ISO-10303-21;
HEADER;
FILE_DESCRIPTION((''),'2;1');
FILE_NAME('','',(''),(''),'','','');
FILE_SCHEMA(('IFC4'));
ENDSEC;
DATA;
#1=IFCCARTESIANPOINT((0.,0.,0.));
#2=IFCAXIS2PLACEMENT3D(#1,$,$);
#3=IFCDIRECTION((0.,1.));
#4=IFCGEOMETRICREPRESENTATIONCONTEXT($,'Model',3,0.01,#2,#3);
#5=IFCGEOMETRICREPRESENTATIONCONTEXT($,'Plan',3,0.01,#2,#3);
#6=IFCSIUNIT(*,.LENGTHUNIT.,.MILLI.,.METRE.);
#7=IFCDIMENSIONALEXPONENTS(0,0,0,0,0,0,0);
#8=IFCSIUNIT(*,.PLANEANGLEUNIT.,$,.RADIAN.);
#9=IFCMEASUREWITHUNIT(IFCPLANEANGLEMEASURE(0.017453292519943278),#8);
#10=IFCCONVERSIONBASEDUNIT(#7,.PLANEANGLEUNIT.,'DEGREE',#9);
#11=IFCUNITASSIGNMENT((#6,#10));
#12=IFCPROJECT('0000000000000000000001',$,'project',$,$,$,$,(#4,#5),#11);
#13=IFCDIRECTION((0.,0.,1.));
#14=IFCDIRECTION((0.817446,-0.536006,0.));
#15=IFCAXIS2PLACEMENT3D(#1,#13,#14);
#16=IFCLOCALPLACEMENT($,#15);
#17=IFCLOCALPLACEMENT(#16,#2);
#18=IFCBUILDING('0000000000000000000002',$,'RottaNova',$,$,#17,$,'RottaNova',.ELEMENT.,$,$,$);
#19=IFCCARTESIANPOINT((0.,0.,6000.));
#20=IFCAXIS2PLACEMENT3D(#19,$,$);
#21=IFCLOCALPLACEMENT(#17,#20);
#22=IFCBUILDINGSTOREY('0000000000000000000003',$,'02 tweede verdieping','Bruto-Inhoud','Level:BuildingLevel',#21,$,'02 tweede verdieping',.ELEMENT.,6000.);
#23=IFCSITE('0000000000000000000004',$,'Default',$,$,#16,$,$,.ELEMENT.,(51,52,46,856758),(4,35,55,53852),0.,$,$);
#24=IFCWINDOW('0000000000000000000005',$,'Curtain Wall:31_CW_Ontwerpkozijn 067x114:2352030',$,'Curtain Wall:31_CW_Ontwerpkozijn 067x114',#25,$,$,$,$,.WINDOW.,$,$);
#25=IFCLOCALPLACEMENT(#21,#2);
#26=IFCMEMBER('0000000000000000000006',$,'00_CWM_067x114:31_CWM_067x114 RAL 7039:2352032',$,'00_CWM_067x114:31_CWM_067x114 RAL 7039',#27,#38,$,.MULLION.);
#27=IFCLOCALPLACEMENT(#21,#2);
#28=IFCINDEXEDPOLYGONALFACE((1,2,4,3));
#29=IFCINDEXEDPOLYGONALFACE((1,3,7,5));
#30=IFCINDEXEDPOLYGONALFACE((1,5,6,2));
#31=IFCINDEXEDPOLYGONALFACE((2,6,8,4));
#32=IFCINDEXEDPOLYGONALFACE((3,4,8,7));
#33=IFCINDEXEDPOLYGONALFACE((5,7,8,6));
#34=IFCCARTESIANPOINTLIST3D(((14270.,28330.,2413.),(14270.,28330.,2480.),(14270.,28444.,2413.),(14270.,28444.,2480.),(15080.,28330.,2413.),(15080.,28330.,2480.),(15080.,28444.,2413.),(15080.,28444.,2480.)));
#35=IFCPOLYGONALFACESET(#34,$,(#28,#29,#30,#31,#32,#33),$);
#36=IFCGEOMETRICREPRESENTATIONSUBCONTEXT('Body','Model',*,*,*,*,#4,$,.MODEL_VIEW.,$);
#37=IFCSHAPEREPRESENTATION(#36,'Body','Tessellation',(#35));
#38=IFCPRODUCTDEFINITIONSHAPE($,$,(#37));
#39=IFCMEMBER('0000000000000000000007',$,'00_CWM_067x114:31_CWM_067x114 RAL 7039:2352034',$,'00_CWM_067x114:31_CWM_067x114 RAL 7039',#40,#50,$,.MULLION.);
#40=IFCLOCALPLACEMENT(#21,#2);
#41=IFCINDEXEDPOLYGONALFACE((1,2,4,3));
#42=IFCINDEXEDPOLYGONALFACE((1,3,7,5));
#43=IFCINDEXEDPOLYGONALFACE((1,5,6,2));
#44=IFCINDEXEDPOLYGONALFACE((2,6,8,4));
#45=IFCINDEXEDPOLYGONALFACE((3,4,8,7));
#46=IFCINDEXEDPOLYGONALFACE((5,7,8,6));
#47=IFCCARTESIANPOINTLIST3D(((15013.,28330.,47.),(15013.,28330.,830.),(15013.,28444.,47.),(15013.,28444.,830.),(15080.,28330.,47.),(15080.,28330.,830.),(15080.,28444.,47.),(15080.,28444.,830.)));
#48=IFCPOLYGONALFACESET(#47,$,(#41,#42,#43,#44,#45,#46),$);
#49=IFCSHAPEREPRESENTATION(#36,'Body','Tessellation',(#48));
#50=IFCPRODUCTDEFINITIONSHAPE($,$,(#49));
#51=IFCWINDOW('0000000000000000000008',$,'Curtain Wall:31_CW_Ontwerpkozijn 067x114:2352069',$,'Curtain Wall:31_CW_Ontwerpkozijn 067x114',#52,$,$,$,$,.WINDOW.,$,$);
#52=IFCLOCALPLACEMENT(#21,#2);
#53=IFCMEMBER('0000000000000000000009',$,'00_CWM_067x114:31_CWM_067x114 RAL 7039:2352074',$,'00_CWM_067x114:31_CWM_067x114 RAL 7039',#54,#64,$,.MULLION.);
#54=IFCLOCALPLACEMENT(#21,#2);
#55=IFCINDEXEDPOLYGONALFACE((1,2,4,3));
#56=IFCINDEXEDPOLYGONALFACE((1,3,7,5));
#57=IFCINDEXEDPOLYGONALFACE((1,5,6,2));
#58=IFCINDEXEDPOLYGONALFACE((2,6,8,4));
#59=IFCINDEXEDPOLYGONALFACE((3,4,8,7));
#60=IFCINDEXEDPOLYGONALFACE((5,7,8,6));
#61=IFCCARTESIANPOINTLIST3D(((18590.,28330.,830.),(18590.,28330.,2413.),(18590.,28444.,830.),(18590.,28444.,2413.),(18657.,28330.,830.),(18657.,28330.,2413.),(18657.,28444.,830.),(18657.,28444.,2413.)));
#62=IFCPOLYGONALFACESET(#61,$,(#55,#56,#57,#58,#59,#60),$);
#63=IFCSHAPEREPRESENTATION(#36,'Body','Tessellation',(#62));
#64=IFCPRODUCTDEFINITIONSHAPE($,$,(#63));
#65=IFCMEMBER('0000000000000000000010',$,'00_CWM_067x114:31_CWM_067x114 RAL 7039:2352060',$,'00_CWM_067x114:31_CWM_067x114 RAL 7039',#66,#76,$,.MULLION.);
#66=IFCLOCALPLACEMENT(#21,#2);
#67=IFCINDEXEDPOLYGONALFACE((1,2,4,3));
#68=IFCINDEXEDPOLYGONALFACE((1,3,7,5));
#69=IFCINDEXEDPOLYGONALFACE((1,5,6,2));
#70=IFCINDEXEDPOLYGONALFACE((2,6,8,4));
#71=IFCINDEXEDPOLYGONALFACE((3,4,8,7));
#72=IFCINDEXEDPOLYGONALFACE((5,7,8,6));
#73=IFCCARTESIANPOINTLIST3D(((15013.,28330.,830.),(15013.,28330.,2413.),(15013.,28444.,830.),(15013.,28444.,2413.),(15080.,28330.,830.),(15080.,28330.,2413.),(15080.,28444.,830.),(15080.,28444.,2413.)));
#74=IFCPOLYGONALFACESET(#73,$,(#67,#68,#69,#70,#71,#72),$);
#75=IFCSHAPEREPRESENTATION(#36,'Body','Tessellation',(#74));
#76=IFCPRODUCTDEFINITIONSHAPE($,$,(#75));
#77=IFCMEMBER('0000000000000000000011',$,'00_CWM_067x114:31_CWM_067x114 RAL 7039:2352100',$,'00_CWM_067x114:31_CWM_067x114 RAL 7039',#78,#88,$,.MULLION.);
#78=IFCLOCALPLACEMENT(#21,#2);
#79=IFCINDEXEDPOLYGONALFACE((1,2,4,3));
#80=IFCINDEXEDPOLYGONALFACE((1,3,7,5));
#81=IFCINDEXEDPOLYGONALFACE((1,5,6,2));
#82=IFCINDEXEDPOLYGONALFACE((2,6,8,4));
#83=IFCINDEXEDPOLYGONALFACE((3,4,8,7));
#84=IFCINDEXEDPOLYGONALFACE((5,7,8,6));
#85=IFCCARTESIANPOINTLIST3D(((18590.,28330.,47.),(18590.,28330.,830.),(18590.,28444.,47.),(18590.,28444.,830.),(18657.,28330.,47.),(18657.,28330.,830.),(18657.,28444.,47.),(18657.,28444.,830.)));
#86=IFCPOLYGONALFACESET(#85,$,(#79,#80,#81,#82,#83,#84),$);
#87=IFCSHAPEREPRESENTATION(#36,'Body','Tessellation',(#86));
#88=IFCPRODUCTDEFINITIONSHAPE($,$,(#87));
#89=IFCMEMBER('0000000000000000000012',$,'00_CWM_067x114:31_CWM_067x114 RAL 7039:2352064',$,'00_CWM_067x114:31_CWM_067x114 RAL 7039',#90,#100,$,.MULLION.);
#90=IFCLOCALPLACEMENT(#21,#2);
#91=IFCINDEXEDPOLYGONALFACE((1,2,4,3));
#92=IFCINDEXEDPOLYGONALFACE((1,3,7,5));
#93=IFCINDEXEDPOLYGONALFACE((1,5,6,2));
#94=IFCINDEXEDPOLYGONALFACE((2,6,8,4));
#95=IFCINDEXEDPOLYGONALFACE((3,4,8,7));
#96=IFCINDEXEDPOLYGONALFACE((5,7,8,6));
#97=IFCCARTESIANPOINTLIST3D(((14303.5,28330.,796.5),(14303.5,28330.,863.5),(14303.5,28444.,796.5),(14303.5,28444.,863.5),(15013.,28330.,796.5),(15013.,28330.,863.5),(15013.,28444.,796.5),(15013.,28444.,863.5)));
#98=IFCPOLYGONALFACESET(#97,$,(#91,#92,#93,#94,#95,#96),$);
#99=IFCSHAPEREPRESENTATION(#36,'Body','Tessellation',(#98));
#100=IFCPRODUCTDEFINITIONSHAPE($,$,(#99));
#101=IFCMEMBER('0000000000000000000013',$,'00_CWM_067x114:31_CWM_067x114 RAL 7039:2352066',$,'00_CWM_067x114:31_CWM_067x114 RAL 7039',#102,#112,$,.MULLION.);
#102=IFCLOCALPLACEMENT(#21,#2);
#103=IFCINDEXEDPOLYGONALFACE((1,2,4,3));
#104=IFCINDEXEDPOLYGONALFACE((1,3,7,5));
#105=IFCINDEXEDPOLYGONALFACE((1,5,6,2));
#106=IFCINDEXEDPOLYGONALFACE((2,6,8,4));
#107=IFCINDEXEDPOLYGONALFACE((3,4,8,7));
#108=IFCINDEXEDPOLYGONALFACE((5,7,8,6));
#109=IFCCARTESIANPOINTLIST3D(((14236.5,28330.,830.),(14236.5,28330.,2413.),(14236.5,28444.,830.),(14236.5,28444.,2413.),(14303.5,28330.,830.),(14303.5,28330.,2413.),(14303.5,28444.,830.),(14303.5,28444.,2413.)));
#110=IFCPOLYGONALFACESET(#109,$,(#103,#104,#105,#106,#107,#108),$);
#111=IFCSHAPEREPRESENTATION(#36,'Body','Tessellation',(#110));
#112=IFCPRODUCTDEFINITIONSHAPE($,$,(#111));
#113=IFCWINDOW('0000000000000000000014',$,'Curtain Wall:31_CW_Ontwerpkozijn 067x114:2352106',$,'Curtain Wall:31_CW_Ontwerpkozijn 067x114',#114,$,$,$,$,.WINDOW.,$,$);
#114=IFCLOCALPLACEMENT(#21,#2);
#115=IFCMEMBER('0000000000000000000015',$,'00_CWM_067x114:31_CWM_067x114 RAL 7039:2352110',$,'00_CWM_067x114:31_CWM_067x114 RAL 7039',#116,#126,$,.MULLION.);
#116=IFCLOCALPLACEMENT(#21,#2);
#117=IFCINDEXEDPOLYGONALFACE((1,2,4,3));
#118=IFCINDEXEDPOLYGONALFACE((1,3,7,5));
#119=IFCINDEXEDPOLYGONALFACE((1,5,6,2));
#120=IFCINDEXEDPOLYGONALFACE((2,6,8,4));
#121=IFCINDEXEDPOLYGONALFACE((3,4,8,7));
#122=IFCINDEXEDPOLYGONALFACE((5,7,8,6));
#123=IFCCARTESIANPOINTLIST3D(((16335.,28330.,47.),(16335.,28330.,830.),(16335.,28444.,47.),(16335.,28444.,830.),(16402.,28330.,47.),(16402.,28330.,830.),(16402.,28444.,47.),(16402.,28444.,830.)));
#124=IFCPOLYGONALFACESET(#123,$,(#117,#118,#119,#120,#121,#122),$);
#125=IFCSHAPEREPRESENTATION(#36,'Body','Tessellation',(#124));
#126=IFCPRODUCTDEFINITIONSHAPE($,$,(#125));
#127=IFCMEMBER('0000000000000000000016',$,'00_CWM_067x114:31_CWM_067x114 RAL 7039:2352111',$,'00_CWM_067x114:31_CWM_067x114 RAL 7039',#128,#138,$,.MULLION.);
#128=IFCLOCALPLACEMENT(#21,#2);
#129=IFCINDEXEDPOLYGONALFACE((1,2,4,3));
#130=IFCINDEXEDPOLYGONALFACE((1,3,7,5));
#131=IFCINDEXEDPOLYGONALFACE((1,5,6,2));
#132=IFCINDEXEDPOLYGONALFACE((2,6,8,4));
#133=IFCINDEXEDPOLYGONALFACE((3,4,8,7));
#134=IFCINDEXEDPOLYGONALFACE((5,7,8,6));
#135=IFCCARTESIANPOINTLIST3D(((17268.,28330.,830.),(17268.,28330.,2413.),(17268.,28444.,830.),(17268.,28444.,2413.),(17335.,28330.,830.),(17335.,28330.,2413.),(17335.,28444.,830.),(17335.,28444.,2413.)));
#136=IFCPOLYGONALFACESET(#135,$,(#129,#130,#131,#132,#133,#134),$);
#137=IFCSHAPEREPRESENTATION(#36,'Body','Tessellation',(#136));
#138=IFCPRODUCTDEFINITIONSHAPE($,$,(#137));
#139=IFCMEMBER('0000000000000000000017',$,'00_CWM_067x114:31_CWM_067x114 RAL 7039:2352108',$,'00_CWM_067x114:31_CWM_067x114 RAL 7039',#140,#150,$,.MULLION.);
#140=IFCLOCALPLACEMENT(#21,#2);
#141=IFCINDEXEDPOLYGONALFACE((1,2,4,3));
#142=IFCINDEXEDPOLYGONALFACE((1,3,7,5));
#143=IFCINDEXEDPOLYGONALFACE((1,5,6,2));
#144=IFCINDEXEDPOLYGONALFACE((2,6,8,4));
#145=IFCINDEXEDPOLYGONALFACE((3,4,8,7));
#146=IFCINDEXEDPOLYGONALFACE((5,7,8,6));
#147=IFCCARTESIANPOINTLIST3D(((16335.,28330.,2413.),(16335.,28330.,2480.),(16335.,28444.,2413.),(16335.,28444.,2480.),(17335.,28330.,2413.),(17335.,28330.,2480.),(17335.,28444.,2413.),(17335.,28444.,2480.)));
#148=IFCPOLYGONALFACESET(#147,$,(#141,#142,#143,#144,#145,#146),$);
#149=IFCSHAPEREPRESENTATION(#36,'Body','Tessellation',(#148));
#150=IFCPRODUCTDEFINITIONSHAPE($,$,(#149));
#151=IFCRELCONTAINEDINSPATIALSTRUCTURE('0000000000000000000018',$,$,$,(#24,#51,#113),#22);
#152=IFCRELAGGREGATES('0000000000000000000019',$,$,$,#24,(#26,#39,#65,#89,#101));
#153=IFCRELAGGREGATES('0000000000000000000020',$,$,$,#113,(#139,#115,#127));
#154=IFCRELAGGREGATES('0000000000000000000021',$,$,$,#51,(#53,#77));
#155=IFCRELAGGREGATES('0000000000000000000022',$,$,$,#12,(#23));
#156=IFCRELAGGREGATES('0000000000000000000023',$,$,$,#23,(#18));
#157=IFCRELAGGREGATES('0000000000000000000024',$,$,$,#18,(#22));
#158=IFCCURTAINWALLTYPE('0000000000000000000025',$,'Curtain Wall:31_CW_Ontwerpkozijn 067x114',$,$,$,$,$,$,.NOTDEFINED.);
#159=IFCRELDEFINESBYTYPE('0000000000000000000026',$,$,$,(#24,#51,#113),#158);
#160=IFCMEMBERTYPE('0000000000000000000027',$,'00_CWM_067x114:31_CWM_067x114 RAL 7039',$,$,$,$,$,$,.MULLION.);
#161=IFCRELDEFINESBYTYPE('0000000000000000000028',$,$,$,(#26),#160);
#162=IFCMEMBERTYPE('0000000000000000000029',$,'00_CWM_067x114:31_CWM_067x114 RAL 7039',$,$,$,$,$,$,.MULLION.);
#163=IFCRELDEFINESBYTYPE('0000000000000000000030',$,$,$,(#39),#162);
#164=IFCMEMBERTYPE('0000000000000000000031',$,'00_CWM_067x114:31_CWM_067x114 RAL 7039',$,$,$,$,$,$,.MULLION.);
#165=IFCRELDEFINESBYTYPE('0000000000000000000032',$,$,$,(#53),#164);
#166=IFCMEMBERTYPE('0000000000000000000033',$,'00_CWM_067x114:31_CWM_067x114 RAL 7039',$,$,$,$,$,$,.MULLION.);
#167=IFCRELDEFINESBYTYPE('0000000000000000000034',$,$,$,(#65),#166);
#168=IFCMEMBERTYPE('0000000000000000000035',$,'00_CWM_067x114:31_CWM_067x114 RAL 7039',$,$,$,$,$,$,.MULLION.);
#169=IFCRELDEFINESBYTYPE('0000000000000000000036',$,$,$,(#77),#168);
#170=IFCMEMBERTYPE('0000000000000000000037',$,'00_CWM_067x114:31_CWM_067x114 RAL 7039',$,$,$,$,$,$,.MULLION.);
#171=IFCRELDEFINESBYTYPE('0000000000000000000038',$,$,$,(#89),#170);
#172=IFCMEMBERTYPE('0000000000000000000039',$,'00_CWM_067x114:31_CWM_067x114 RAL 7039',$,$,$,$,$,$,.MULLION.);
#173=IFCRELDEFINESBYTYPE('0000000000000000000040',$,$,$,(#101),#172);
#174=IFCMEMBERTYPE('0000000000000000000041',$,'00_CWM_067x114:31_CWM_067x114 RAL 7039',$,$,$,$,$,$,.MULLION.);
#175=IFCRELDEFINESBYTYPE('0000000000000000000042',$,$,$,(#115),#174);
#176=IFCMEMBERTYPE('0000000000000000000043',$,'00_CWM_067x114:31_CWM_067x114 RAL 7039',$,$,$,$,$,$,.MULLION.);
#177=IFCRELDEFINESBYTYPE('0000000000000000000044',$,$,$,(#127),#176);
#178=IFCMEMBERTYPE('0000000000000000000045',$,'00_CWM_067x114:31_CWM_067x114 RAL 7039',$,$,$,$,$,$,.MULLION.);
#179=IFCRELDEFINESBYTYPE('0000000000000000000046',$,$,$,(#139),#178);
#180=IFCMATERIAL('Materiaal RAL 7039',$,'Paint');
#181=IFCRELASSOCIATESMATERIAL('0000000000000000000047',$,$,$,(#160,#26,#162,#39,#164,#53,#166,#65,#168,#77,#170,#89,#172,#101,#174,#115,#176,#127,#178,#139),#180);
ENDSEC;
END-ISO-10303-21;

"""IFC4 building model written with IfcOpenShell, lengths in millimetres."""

from ifc_helpers import new_model, entity, si_unit, converted_unit, direction, frame, origin, place, context, subcontext, project, spatial, indexed_curve, outline, extrude, source, transform, mapped, material, type_object, type_shapes, element, aggregate, save


model = new_model("IFC4")

# Units and contexts
model_context = context("Model", 3, precision=0.01, world=origin(), true_north=direction((0.0, 1.0)))
plan_context = context("Plan", 3, precision=0.01, world=origin(), true_north=direction((0.0, 1.0)))
body_context = subcontext(model_context, "Body", "Model", "MODEL_VIEW")
ifc_project = project(units=[si_unit("LENGTHUNIT", "METRE", prefix="MILLI"), converted_unit("PLANEANGLEUNIT", "DEGREE", entity("IfcPlaneAngleMeasure", 0.017453292519943278), si_unit("PLANEANGLEUNIT", "RADIAN"), dimensions=[0, 0, 0, 0, 0, 0, 0])], contexts=[model_context, plan_context])

# Site, building, storey
site_placement = place(None, frame((0.0, 0.0, 0.0), z_axis=(0.0, 0.0, 1.0), x_axis=(0.817446, -0.536006, 0.0)))
site = spatial("IfcSite", under=ifc_project, at=site_placement, Name="Default", CompositionType="ELEMENT", RefLatitude=(51, 52, 46, 856758), RefLongitude=(4, 35, 55, 53852), RefElevation=0.0)
building_placement = place(site_placement, origin())
building = spatial("IfcBuilding", under=site, at=building_placement, Name="RottaNova", LongName="RottaNova", CompositionType="ELEMENT")
storey_placement = place(building_placement, frame((0.0, 0.0, 6000.0)))
storey = spatial("IfcBuildingStorey", under=building, at=storey_placement, Name="02 tweede verdieping", Description="Bruto-Inhoud", ObjectType="Level:BuildingLevel", LongName="02 tweede verdieping", CompositionType="ELEMENT", Elevation=6000.0)

# Window, members
curtain_wall_type = type_object("IfcCurtainWallType", Name="Curtain Wall:31_CW_Ontwerpkozijn 067x114", PredefinedType="NOTDEFINED")
window_1_placement = place(storey_placement, frame((0.0, 0.0, -6000.0)))
window_1 = element("IfcWindow", 1, at=window_1_placement, inside=storey, type_object=curtain_wall_type, Name="Curtain Wall:31_CW_Ontwerpkozijn 067x114:2352030", ObjectType="Curtain Wall:31_CW_Ontwerpkozijn 067x114", PredefinedType="WINDOW")
ifc_material_1 = material(Name="Materiaal RAL 7039", Category="Paint")
member_type_1 = type_object("IfcMemberType", Name="00_CWM_067x114:31_CWM_067x114 RAL 7039", PredefinedType="MULLION", material=ifc_material_1)
shared_shape_1 = source(origin(), body_context, "Body", "SweptSolid", [
    extrude(outline(indexed_curve([(-33.5, -57.0), (33.5, -57.0), (33.5, 57.0), (-33.5, 57.0), (-33.5, -57.0)], self_intersect=False)), frame((-33.5, -57.0, -810.0), z_axis=(0.0, 0.0, 1.0), x_axis=(-1.0, 0.0, 0.0)), (0.0, 0.0, 1.0), 810.0),
])
type_shapes(member_type_1, [shared_shape_1])
member_1_placement = place(window_1_placement, frame((15080.0, 28330.0, 8480.0), z_axis=(1.0, 0.0, 0.0), x_axis=(0.0, 0.0, 1.0)))
member_1 = element("IfcMember", 2, at=member_1_placement, type_object=member_type_1, material=ifc_material_1, Name="00_CWM_067x114:31_CWM_067x114 RAL 7039:2352032", ObjectType="00_CWM_067x114:31_CWM_067x114 RAL 7039", PredefinedType="MULLION", context=body_context, shape_type="MappedRepresentation", body=[
    mapped(shared_shape_1, transform((0.0, 0.0, 0.0), scale=1.0)),
])
member_type_2 = type_object("IfcMemberType", Name="00_CWM_067x114:31_CWM_067x114 RAL 7039", PredefinedType="MULLION", material=ifc_material_1)
shared_shape_2 = source(origin(), body_context, "Body", "SweptSolid", [
    extrude(outline(indexed_curve([(-33.5, -57.0), (33.5, -57.0), (33.5, 57.0), (-33.5, 57.0), (-33.5, -57.0)], self_intersect=False)), frame((-33.5, -57.0, -783.0), z_axis=(0.0, 0.0, 1.0), x_axis=(-1.0, 0.0, 0.0)), (0.0, 0.0, 1.0), 783.0),
])
type_shapes(member_type_2, [shared_shape_2])
member_2_placement = place(window_1_placement, frame((15080.0, 28330.0, 6047.0), z_axis=(0.0, 0.0, -1.0), x_axis=(1.0, 0.0, 0.0)))
member_2 = element("IfcMember", 3, at=member_2_placement, type_object=member_type_2, material=ifc_material_1, Name="00_CWM_067x114:31_CWM_067x114 RAL 7039:2352034", ObjectType="00_CWM_067x114:31_CWM_067x114 RAL 7039", PredefinedType="MULLION", context=body_context, shape_type="MappedRepresentation", body=[
    mapped(shared_shape_2, transform((0.0, 0.0, 0.0), scale=1.0)),
])

# Window, member
window_2_placement = place(storey_placement, frame((0.0, 0.0, -6000.0)))
window_2 = element("IfcWindow", 4, at=window_2_placement, inside=storey, type_object=curtain_wall_type, Name="Curtain Wall:31_CW_Ontwerpkozijn 067x114:2352069", ObjectType="Curtain Wall:31_CW_Ontwerpkozijn 067x114", PredefinedType="WINDOW")
member_type_3 = type_object("IfcMemberType", Name="00_CWM_067x114:31_CWM_067x114 RAL 7039", PredefinedType="MULLION", material=ifc_material_1)
shared_shape_3 = source(origin(), body_context, "Body", "SweptSolid", [
    extrude(outline(indexed_curve([(-33.5, -57.0), (33.5, -57.0), (33.5, 57.0), (-33.5, 57.0), (-33.5, -57.0)], self_intersect=False)), frame((-33.5, -57.0, -1583.0), z_axis=(0.0, 0.0, 1.0), x_axis=(-1.0, 0.0, 0.0)), (0.0, 0.0, 1.0), 1583.0),
])
type_shapes(member_type_3, [shared_shape_3])
member_3_placement = place(window_2_placement, frame((18590.0, 28330.0, 8413.0), z_axis=(0.0, 0.0, 1.0), x_axis=(-1.0, 0.0, 0.0)))
member_3 = element("IfcMember", 5, at=member_3_placement, type_object=member_type_3, material=ifc_material_1, Name="00_CWM_067x114:31_CWM_067x114 RAL 7039:2352074", ObjectType="00_CWM_067x114:31_CWM_067x114 RAL 7039", PredefinedType="MULLION", context=body_context, shape_type="MappedRepresentation", body=[
    mapped(shared_shape_3, transform((0.0, 0.0, 0.0), scale=1.0)),
])

# Members
member_type_4 = type_object("IfcMemberType", Name="00_CWM_067x114:31_CWM_067x114 RAL 7039", PredefinedType="MULLION", material=ifc_material_1)
shared_shape_4 = source(origin(), body_context, "Body", "SweptSolid", [
    extrude(outline(indexed_curve([(-33.5, -57.0), (33.5, -57.0), (33.5, 57.0), (-33.5, 57.0), (-33.5, -57.0)], self_intersect=False)), frame((-33.5, -57.0, -1583.0), z_axis=(0.0, 0.0, 1.0), x_axis=(-1.0, 0.0, 0.0)), (0.0, 0.0, 1.0), 1583.0),
])
type_shapes(member_type_4, [shared_shape_4])
member_4_placement = place(window_1_placement, frame((15080.0, 28330.0, 6830.0), z_axis=(0.0, 0.0, -1.0), x_axis=(1.0, 0.0, 0.0)))
member_4 = element("IfcMember", 6, at=member_4_placement, type_object=member_type_4, material=ifc_material_1, Name="00_CWM_067x114:31_CWM_067x114 RAL 7039:2352060", ObjectType="00_CWM_067x114:31_CWM_067x114 RAL 7039", PredefinedType="MULLION", context=body_context, shape_type="MappedRepresentation", body=[
    mapped(shared_shape_4, transform((0.0, 0.0, 0.0), scale=1.0)),
])
member_type_5 = type_object("IfcMemberType", Name="00_CWM_067x114:31_CWM_067x114 RAL 7039", PredefinedType="MULLION", material=ifc_material_1)
shared_shape_5 = source(origin(), body_context, "Body", "SweptSolid", [
    extrude(outline(indexed_curve([(-33.5, -57.0), (33.5, -57.0), (33.5, 57.0), (-33.5, 57.0), (-33.5, -57.0)], self_intersect=False)), frame((-33.5, -57.0, -783.0), z_axis=(0.0, 0.0, 1.0), x_axis=(-1.0, 0.0, 0.0)), (0.0, 0.0, 1.0), 783.0),
])
type_shapes(member_type_5, [shared_shape_5])
member_5_placement = place(window_2_placement, frame((18590.0, 28330.0, 6830.0), z_axis=(0.0, 0.0, 1.0), x_axis=(-1.0, 0.0, 0.0)))
member_5 = element("IfcMember", 7, at=member_5_placement, type_object=member_type_5, material=ifc_material_1, Name="00_CWM_067x114:31_CWM_067x114 RAL 7039:2352100", ObjectType="00_CWM_067x114:31_CWM_067x114 RAL 7039", PredefinedType="MULLION", context=body_context, shape_type="MappedRepresentation", body=[
    mapped(shared_shape_5, transform((0.0, 0.0, 0.0), scale=1.0)),
])
member_type_6 = type_object("IfcMemberType", Name="00_CWM_067x114:31_CWM_067x114 RAL 7039", PredefinedType="MULLION", material=ifc_material_1)
shared_shape_6 = source(origin(), body_context, "Body", "SweptSolid", [
    extrude(outline(indexed_curve([(-33.5, -57.0), (33.5, -57.0), (33.5, 57.0), (-33.5, 57.0), (-33.5, -57.0)], self_intersect=False)), frame((0.0, -57.0, -709.5), z_axis=(0.0, 0.0, 1.0), x_axis=(-1.0, 0.0, 0.0)), (0.0, 0.0, 1.0), 709.5),
])
type_shapes(member_type_6, [shared_shape_6])
member_6_placement = place(window_1_placement, frame((15013.0, 28330.0, 6830.0), z_axis=(1.0, 0.0, 0.0), x_axis=(0.0, 0.0, 1.0)))
member_6 = element("IfcMember", 8, at=member_6_placement, type_object=member_type_6, material=ifc_material_1, Name="00_CWM_067x114:31_CWM_067x114 RAL 7039:2352064", ObjectType="00_CWM_067x114:31_CWM_067x114 RAL 7039", PredefinedType="MULLION", context=body_context, shape_type="MappedRepresentation", body=[
    mapped(shared_shape_6, transform((0.0, 0.0, 0.0), scale=1.0)),
])
member_type_7 = type_object("IfcMemberType", Name="00_CWM_067x114:31_CWM_067x114 RAL 7039", PredefinedType="MULLION", material=ifc_material_1)
shared_shape_7 = source(origin(), body_context, "Body", "SweptSolid", [
    extrude(outline(indexed_curve([(-33.5, -57.0), (33.5, -57.0), (33.5, 57.0), (-33.5, 57.0), (-33.5, -57.0)], self_intersect=False)), frame((0.0, -57.0, -1583.0), z_axis=(0.0, 0.0, 1.0), x_axis=(-1.0, 0.0, 0.0)), (0.0, 0.0, 1.0), 1583.0),
])
type_shapes(member_type_7, [shared_shape_7])
member_7_placement = place(window_1_placement, frame((14270.0, 28330.0, 6830.0), z_axis=(0.0, 0.0, -1.0), x_axis=(1.0, 0.0, 0.0)))
member_7 = element("IfcMember", 9, at=member_7_placement, type_object=member_type_7, material=ifc_material_1, Name="00_CWM_067x114:31_CWM_067x114 RAL 7039:2352066", ObjectType="00_CWM_067x114:31_CWM_067x114 RAL 7039", PredefinedType="MULLION", context=body_context, shape_type="MappedRepresentation", body=[
    mapped(shared_shape_7, transform((0.0, 0.0, 0.0), scale=1.0)),
])

# Window, members
window_3_placement = place(storey_placement, frame((0.0, 0.0, -6000.0)))
window_3 = element("IfcWindow", 10, at=window_3_placement, inside=storey, type_object=curtain_wall_type, Name="Curtain Wall:31_CW_Ontwerpkozijn 067x114:2352106", ObjectType="Curtain Wall:31_CW_Ontwerpkozijn 067x114", PredefinedType="WINDOW")
member_type_8 = type_object("IfcMemberType", Name="00_CWM_067x114:31_CWM_067x114 RAL 7039", PredefinedType="MULLION", material=ifc_material_1)
shared_shape_8 = source(origin(), body_context, "Body", "SweptSolid", [
    extrude(outline(indexed_curve([(-33.5, -57.0), (33.5, -57.0), (33.5, 57.0), (-33.5, 57.0), (-33.5, -57.0)], self_intersect=False)), frame((-33.5, 57.0, -783.0), z_axis=(0.0, 0.0, 1.0), x_axis=(-1.0, 0.0, 0.0)), (0.0, 0.0, 1.0), 783.0),
])
type_shapes(member_type_8, [shared_shape_8])
member_8_placement = place(window_3_placement, frame((16335.0, 28330.0, 6047.0), z_axis=(0.0, 0.0, -1.0), x_axis=(-1.0, 0.0, 0.0)))
member_8 = element("IfcMember", 11, at=member_8_placement, type_object=member_type_8, material=ifc_material_1, Name="00_CWM_067x114:31_CWM_067x114 RAL 7039:2352110", ObjectType="00_CWM_067x114:31_CWM_067x114 RAL 7039", PredefinedType="MULLION", context=body_context, shape_type="MappedRepresentation", body=[
    mapped(shared_shape_8, transform((0.0, 0.0, 0.0), scale=1.0)),
])
member_type_9 = type_object("IfcMemberType", Name="00_CWM_067x114:31_CWM_067x114 RAL 7039", PredefinedType="MULLION", material=ifc_material_1)
shared_shape_9 = source(origin(), body_context, "Body", "SweptSolid", [
    extrude(outline(indexed_curve([(-33.5, -57.0), (33.5, -57.0), (33.5, 57.0), (-33.5, 57.0), (-33.5, -57.0)], self_intersect=False)), frame((-33.5, 57.0, -1583.0), z_axis=(0.0, 0.0, 1.0), x_axis=(-1.0, 0.0, 0.0)), (0.0, 0.0, 1.0), 1583.0),
])
type_shapes(member_type_9, [shared_shape_9])
member_9_placement = place(window_3_placement, frame((17335.0, 28330.0, 8413.0)))
member_9 = element("IfcMember", 12, at=member_9_placement, type_object=member_type_9, material=ifc_material_1, Name="00_CWM_067x114:31_CWM_067x114 RAL 7039:2352111", ObjectType="00_CWM_067x114:31_CWM_067x114 RAL 7039", PredefinedType="MULLION", context=body_context, shape_type="MappedRepresentation", body=[
    mapped(shared_shape_9, transform((0.0, 0.0, 0.0), scale=1.0)),
])
member_type_10 = type_object("IfcMemberType", Name="00_CWM_067x114:31_CWM_067x114 RAL 7039", PredefinedType="MULLION", material=ifc_material_1)
shared_shape_10 = source(origin(), body_context, "Body", "SweptSolid", [
    extrude(outline(indexed_curve([(-33.5, -57.0), (33.5, -57.0), (33.5, 57.0), (-33.5, 57.0), (-33.5, -57.0)], self_intersect=False)), frame((-33.5, 57.0, -1000.0), z_axis=(0.0, 0.0, 1.0), x_axis=(-1.0, 0.0, 0.0)), (0.0, 0.0, 1.0), 1000.0),
])
type_shapes(member_type_10, [shared_shape_10])
member_10_placement = place(window_3_placement, frame((16335.0, 28330.0, 8480.0), z_axis=(-1.0, 0.0, 0.0), x_axis=(0.0, 0.0, 1.0)))
member_10 = element("IfcMember", 13, at=member_10_placement, type_object=member_type_10, material=ifc_material_1, Name="00_CWM_067x114:31_CWM_067x114 RAL 7039:2352108", ObjectType="00_CWM_067x114:31_CWM_067x114 RAL 7039", PredefinedType="MULLION", context=body_context, shape_type="MappedRepresentation", body=[
    mapped(shared_shape_10, transform((0.0, 0.0, 0.0), scale=1.0)),
])

aggregate(window_1, [member_1, member_2, member_4, member_6, member_7])
aggregate(window_3, [member_10, member_8, member_9])
aggregate(window_2, [member_3, member_5])

save(model, "model.ifc")
